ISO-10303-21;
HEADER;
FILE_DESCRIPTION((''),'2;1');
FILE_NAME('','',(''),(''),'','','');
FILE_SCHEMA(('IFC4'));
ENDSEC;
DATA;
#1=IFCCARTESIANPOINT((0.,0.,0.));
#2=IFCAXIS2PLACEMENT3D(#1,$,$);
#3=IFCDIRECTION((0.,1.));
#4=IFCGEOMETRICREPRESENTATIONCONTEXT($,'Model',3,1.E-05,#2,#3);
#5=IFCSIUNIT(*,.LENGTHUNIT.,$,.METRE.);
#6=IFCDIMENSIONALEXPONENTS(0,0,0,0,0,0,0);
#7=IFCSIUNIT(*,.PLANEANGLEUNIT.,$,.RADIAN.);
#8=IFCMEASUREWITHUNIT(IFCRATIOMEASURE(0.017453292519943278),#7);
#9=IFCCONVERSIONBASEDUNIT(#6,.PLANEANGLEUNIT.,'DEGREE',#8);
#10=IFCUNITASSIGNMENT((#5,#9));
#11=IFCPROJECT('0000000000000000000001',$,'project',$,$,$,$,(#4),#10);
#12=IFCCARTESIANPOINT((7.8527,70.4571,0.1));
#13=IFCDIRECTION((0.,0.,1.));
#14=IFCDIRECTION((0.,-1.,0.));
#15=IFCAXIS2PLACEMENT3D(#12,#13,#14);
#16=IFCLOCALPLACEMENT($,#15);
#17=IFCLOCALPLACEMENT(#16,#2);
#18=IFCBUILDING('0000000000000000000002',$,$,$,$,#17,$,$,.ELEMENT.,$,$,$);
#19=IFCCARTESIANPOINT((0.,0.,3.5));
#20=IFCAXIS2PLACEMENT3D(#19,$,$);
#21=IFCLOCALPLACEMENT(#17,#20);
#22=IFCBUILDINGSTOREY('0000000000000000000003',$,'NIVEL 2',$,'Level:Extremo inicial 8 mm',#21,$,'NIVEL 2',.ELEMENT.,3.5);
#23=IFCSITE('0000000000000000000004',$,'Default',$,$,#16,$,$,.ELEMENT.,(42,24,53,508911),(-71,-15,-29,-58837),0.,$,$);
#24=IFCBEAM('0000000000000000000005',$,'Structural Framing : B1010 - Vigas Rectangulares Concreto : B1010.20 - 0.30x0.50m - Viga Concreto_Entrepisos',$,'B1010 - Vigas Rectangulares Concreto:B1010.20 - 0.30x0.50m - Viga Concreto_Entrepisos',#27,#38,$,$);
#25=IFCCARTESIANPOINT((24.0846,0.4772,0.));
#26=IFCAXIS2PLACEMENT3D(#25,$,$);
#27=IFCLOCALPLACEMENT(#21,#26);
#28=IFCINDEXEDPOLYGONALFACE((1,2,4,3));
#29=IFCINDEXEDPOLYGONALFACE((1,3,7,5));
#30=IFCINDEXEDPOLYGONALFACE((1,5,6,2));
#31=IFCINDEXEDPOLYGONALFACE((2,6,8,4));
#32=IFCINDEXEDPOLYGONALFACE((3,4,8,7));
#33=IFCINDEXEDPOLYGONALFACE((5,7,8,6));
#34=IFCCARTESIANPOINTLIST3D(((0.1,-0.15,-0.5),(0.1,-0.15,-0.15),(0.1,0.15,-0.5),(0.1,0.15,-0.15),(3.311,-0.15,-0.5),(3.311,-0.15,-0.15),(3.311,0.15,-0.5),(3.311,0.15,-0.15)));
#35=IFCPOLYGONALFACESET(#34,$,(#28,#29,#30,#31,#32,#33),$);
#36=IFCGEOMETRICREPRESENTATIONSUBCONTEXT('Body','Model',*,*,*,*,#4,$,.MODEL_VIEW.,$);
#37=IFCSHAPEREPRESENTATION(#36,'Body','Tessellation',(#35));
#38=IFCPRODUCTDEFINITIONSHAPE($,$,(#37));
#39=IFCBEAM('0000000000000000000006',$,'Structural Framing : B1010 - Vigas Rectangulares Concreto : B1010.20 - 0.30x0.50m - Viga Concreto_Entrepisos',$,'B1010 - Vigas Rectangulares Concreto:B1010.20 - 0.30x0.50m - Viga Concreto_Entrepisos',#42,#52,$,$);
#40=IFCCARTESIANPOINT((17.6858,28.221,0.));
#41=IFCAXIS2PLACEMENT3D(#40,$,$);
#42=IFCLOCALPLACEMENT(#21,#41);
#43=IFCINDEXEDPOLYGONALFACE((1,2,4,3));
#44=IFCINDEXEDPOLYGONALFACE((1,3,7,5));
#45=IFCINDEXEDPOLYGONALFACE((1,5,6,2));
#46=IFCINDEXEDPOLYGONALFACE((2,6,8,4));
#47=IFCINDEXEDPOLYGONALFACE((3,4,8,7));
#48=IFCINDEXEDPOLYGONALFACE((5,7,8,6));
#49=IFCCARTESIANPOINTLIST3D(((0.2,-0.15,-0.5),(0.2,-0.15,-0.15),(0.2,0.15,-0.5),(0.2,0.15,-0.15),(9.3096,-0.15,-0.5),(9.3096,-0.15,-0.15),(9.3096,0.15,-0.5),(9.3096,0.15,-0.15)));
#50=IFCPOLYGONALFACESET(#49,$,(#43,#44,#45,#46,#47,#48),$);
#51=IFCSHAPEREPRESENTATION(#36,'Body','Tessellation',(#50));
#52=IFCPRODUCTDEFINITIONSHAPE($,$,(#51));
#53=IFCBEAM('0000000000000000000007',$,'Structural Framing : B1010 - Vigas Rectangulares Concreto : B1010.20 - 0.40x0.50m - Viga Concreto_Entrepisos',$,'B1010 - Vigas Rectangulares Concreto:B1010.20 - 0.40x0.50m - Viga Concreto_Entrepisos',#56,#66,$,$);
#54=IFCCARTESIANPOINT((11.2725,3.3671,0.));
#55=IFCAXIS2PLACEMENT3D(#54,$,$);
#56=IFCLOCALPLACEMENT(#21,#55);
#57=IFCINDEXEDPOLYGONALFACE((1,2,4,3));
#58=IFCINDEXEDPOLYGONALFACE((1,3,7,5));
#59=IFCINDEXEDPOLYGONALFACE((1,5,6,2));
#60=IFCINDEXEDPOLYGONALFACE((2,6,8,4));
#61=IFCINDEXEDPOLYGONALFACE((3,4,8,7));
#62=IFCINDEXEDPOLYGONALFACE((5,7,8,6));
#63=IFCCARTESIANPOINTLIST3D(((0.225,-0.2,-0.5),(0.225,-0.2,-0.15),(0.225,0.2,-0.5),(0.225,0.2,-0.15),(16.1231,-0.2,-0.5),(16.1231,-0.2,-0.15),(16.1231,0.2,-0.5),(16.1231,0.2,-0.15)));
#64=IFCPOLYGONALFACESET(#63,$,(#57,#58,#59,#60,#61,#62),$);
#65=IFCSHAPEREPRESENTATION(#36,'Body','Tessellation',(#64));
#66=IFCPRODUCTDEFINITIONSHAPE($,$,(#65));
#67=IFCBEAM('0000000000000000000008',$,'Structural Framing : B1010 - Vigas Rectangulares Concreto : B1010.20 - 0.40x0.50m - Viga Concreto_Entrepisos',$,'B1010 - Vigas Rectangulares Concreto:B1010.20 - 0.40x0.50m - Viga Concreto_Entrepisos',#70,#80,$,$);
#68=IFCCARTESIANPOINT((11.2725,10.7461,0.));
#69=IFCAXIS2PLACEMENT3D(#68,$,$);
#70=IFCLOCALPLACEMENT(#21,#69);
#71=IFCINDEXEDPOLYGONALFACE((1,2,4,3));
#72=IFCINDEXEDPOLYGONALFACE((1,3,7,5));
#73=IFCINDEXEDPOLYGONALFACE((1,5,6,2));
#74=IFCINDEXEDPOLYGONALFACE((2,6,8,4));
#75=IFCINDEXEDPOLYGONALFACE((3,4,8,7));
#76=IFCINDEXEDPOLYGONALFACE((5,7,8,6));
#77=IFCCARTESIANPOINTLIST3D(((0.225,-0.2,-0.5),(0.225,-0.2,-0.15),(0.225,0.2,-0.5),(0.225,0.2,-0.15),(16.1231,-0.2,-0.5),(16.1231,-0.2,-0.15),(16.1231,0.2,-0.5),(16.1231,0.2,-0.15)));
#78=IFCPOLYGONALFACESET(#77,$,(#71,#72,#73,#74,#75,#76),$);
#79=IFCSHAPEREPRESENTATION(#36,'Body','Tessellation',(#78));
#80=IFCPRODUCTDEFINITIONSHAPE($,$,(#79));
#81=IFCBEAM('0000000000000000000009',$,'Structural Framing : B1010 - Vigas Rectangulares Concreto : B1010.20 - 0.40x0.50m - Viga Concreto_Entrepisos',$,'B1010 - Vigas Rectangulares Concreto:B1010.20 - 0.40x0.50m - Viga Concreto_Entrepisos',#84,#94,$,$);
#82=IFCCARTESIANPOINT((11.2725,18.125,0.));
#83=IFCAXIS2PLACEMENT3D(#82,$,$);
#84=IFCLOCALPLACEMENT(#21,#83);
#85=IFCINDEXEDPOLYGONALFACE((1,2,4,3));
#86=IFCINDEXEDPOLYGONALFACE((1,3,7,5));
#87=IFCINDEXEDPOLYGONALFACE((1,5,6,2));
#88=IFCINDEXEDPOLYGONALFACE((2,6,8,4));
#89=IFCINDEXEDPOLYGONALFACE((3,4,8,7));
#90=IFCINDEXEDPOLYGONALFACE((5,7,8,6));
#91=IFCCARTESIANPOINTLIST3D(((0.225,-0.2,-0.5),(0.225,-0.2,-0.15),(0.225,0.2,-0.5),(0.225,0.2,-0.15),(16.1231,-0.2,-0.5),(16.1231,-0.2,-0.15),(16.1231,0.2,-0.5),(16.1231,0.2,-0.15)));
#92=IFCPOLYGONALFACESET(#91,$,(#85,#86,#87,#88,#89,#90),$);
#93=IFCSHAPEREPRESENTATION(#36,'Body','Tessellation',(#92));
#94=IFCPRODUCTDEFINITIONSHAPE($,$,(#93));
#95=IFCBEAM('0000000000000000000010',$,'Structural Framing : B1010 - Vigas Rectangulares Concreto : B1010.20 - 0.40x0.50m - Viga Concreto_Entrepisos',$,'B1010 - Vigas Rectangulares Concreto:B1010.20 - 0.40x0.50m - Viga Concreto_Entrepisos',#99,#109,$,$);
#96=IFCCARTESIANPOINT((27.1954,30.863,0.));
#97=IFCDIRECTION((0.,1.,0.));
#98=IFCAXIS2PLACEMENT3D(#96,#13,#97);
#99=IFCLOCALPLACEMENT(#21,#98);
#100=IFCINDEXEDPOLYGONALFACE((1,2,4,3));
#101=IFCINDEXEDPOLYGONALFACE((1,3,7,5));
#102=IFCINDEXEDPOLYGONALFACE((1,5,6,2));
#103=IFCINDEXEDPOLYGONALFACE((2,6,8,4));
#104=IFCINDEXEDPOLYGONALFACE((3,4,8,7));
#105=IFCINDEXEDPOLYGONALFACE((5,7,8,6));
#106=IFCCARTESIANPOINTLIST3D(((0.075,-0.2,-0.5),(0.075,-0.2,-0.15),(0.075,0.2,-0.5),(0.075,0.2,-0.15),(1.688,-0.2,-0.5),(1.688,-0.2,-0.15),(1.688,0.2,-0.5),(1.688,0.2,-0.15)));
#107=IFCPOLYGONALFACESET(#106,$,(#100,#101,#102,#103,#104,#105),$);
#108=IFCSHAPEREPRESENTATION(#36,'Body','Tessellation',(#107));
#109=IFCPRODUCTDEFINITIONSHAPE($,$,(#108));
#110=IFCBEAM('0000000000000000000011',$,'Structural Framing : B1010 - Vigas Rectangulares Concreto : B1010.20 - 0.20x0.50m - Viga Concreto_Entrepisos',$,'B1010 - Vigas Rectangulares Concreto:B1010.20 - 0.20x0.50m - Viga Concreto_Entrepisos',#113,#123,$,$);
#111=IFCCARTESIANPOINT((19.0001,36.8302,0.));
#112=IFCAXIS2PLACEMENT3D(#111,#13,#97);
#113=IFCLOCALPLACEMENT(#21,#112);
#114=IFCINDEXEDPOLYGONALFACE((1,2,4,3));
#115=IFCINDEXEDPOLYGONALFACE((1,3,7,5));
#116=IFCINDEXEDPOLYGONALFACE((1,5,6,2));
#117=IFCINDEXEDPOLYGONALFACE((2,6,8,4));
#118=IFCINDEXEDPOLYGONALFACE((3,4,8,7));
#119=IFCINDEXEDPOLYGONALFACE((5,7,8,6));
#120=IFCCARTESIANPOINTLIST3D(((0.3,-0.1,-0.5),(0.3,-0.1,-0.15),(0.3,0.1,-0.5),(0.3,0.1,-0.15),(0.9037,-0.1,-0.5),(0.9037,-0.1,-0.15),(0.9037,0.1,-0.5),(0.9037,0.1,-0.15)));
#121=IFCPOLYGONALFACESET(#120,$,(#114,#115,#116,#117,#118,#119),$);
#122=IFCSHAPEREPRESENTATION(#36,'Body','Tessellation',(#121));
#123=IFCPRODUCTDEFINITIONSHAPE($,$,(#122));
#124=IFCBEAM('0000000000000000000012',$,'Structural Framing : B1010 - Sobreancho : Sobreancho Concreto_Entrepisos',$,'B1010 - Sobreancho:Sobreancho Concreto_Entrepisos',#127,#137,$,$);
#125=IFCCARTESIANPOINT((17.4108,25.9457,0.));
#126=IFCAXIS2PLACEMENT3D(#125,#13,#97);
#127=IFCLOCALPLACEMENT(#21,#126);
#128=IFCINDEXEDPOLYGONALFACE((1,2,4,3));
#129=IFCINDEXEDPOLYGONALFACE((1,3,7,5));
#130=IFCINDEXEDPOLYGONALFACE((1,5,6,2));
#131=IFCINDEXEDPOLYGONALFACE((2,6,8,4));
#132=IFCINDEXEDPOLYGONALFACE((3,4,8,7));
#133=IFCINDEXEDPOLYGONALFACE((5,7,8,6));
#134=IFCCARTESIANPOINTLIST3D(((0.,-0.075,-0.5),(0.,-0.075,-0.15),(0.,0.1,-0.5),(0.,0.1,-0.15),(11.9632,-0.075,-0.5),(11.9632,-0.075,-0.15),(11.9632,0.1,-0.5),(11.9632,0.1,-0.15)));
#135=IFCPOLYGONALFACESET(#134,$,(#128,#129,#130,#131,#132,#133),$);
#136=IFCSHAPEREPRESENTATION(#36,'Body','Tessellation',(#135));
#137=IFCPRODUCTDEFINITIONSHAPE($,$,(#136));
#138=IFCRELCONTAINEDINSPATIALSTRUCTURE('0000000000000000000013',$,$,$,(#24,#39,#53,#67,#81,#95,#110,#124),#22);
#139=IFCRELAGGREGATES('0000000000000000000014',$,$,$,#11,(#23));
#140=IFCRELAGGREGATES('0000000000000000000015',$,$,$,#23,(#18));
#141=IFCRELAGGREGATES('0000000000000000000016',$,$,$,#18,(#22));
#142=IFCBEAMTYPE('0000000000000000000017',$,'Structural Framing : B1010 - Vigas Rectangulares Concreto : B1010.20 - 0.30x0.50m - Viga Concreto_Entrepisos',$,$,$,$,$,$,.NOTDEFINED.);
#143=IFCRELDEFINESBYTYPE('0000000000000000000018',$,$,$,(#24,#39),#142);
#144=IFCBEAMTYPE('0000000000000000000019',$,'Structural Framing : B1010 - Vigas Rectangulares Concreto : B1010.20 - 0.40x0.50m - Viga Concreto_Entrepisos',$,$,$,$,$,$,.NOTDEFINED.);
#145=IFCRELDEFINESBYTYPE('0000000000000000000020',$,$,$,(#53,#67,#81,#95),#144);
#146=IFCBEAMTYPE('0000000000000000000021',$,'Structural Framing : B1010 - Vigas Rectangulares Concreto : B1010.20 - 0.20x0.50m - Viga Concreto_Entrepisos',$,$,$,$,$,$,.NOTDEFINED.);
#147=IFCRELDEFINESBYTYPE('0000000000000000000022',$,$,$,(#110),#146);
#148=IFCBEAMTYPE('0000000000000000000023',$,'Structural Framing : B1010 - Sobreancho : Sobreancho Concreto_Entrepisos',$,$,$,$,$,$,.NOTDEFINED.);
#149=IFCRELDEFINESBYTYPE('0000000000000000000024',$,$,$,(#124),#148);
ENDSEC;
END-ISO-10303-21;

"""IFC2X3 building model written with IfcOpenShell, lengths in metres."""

from ifc_helpers import new_model, entity, si_unit, converted_unit, direction, frame, frame_2d, origin, place, context, subcontext, project, spatial, rectangle, extrude, type_object, element, save


model = new_model("IFC2X3")

# Units and contexts
model_context = context("Model", 3, precision=1e-05, world=origin(), true_north=direction((0.0, 1.0)))
body_context = subcontext(model_context, "Body", "Model", "MODEL_VIEW")
ifc_project = project(units=[si_unit("LENGTHUNIT", "METRE"), converted_unit("PLANEANGLEUNIT", "DEGREE", entity("IfcRatioMeasure", 0.017453292519943278), si_unit("PLANEANGLEUNIT", "RADIAN"), dimensions=[0, 0, 0, 0, 0, 0, 0])], contexts=[model_context])

# Site, building, storey
site_placement = place(None, frame((7.8527, 70.4571, 0.1), z_axis=(0.0, 0.0, 1.0), x_axis=(0.0, -1.0, 0.0)))
site = spatial("IfcSite", under=ifc_project, at=site_placement, Name="Default", CompositionType="ELEMENT", RefLatitude=(42, 24, 53, 508911), RefLongitude=(-71, -15, -29, -58837), RefElevation=0.0)
building_placement = place(site_placement, origin())
building = spatial("IfcBuilding", under=site, at=building_placement, CompositionType="ELEMENT")
storey_placement = place(building_placement, frame((0.0, 0.0, 3.5)))
storey = spatial("IfcBuildingStorey", under=building, at=storey_placement, Name="NIVEL 2", ObjectType="Level:Extremo inicial 8 mm", LongName="NIVEL 2", CompositionType="ELEMENT", Elevation=3.5)

# Beams
beam_type_1 = type_object("IfcBeamType", Name="Structural Framing : B1010 - Vigas Rectangulares Concreto : B1010.20 - 0.30x0.50m - Viga Concreto_Entrepisos", PredefinedType="NOTDEFINED")
beam_1_placement = place(storey_placement, frame((24.0846, 0.4772, 0.0)))
element("IfcBeam", 1, at=beam_1_placement, inside=storey, type_object=beam_type_1, Name="Structural Framing : B1010 - Vigas Rectangulares Concreto : B1010.20 - 0.30x0.50m - Viga Concreto_Entrepisos", ObjectType="B1010 - Vigas Rectangulares Concreto:B1010.20 - 0.30x0.50m - Viga Concreto_Entrepisos", context=body_context, shape_type="SweptSolid", body=[
    extrude(rectangle(XDim=0.35, YDim=0.3, at=frame_2d((0.0, 0.0), x_axis=(1.0, 0.0))), frame((0.1, 0.0, -0.325), z_axis=(1.0, 0.0, 0.0), x_axis=(0.0, 0.0, -1.0)), (0.0, 0.0, 1.0), 3.211),
])
beam_2_placement = place(storey_placement, frame((17.6858, 28.221, 0.0)))
element("IfcBeam", 2, at=beam_2_placement, inside=storey, type_object=beam_type_1, Name="Structural Framing : B1010 - Vigas Rectangulares Concreto : B1010.20 - 0.30x0.50m - Viga Concreto_Entrepisos", ObjectType="B1010 - Vigas Rectangulares Concreto:B1010.20 - 0.30x0.50m - Viga Concreto_Entrepisos", context=body_context, shape_type="SweptSolid", body=[
    extrude(rectangle(XDim=0.35, YDim=0.3, at=frame_2d((0.0, 0.0), x_axis=(1.0, 0.0))), frame((0.2, 0.0, -0.325), z_axis=(1.0, 0.0, 0.0), x_axis=(0.0, 0.0, -1.0)), (0.0, 0.0, 1.0), 9.1096),
])
beam_type_2 = type_object("IfcBeamType", Name="Structural Framing : B1010 - Vigas Rectangulares Concreto : B1010.20 - 0.40x0.50m - Viga Concreto_Entrepisos", PredefinedType="NOTDEFINED")
beam_3_placement = place(storey_placement, frame((11.2725, 3.3671, 0.0)))
element("IfcBeam", 3, at=beam_3_placement, inside=storey, type_object=beam_type_2, Name="Structural Framing : B1010 - Vigas Rectangulares Concreto : B1010.20 - 0.40x0.50m - Viga Concreto_Entrepisos", ObjectType="B1010 - Vigas Rectangulares Concreto:B1010.20 - 0.40x0.50m - Viga Concreto_Entrepisos", context=body_context, shape_type="SweptSolid", body=[
    extrude(rectangle(XDim=0.35, YDim=0.4, at=frame_2d((0.0, 0.0), x_axis=(1.0, 0.0))), frame((0.225, 0.0, -0.325), z_axis=(1.0, 0.0, 0.0), x_axis=(0.0, 0.0, -1.0)), (0.0, 0.0, 1.0), 15.8981),
])
beam_4_placement = place(storey_placement, frame((11.2725, 10.7461, 0.0)))
element("IfcBeam", 4, at=beam_4_placement, inside=storey, type_object=beam_type_2, Name="Structural Framing : B1010 - Vigas Rectangulares Concreto : B1010.20 - 0.40x0.50m - Viga Concreto_Entrepisos", ObjectType="B1010 - Vigas Rectangulares Concreto:B1010.20 - 0.40x0.50m - Viga Concreto_Entrepisos", context=body_context, shape_type="SweptSolid", body=[
    extrude(rectangle(XDim=0.35, YDim=0.4, at=frame_2d((0.0, 0.0), x_axis=(1.0, 0.0))), frame((0.225, 0.0, -0.325), z_axis=(1.0, 0.0, 0.0), x_axis=(0.0, 0.0, -1.0)), (0.0, 0.0, 1.0), 15.8981),
])
beam_5_placement = place(storey_placement, frame((11.2725, 18.125, 0.0)))
element("IfcBeam", 5, at=beam_5_placement, inside=storey, type_object=beam_type_2, Name="Structural Framing : B1010 - Vigas Rectangulares Concreto : B1010.20 - 0.40x0.50m - Viga Concreto_Entrepisos", ObjectType="B1010 - Vigas Rectangulares Concreto:B1010.20 - 0.40x0.50m - Viga Concreto_Entrepisos", context=body_context, shape_type="SweptSolid", body=[
    extrude(rectangle(XDim=0.35, YDim=0.4, at=frame_2d((0.0, 0.0), x_axis=(1.0, 0.0))), frame((0.225, 0.0, -0.325), z_axis=(1.0, 0.0, 0.0), x_axis=(0.0, 0.0, -1.0)), (0.0, 0.0, 1.0), 15.8981),
])
beam_6_placement = place(storey_placement, frame((27.1954, 30.863, 0.0), z_axis=(0.0, 0.0, 1.0), x_axis=(0.0, 1.0, 0.0)))
element("IfcBeam", 6, at=beam_6_placement, inside=storey, type_object=beam_type_2, Name="Structural Framing : B1010 - Vigas Rectangulares Concreto : B1010.20 - 0.40x0.50m - Viga Concreto_Entrepisos", ObjectType="B1010 - Vigas Rectangulares Concreto:B1010.20 - 0.40x0.50m - Viga Concreto_Entrepisos", context=body_context, shape_type="SweptSolid", body=[
    extrude(rectangle(XDim=0.35, YDim=0.4, at=frame_2d((0.0, 0.0), x_axis=(1.0, 0.0))), frame((0.075, 0.0, -0.325), z_axis=(1.0, 0.0, 0.0), x_axis=(0.0, 0.0, -1.0)), (0.0, 0.0, 1.0), 1.613),
])
beam_type_3 = type_object("IfcBeamType", Name="Structural Framing : B1010 - Vigas Rectangulares Concreto : B1010.20 - 0.20x0.50m - Viga Concreto_Entrepisos", PredefinedType="NOTDEFINED")
beam_7_placement = place(storey_placement, frame((19.0001, 36.8302, 0.0), z_axis=(0.0, 0.0, 1.0), x_axis=(0.0, 1.0, 0.0)))
element("IfcBeam", 7, at=beam_7_placement, inside=storey, type_object=beam_type_3, Name="Structural Framing : B1010 - Vigas Rectangulares Concreto : B1010.20 - 0.20x0.50m - Viga Concreto_Entrepisos", ObjectType="B1010 - Vigas Rectangulares Concreto:B1010.20 - 0.20x0.50m - Viga Concreto_Entrepisos", context=body_context, shape_type="SweptSolid", body=[
    extrude(rectangle(XDim=0.35, YDim=0.2, at=frame_2d((0.0, 0.0), x_axis=(1.0, 0.0))), frame((0.3, 0.0, -0.325), z_axis=(1.0, 0.0, 0.0), x_axis=(0.0, 0.0, -1.0)), (0.0, 0.0, 1.0), 0.6037),
])
beam_type_4 = type_object("IfcBeamType", Name="Structural Framing : B1010 - Sobreancho : Sobreancho Concreto_Entrepisos", PredefinedType="NOTDEFINED")
beam_8_placement = place(storey_placement, frame((17.4108, 25.9457, 0.0), z_axis=(0.0, 0.0, 1.0), x_axis=(0.0, 1.0, 0.0)))
element("IfcBeam", 8, at=beam_8_placement, inside=storey, type_object=beam_type_4, Name="Structural Framing : B1010 - Sobreancho : Sobreancho Concreto_Entrepisos", ObjectType="B1010 - Sobreancho:Sobreancho Concreto_Entrepisos", context=body_context, shape_type="SweptSolid", body=[
    extrude(rectangle(XDim=0.35, YDim=0.175, at=frame_2d((0.0, 0.0), x_axis=(1.0, 0.0))), frame((0.0, 0.0125, -0.325), z_axis=(1.0, 0.0, 0.0), x_axis=(0.0, 0.0, -1.0)), (0.0, 0.0, 1.0), 11.9632),
])

save(model, "model.ifc")
